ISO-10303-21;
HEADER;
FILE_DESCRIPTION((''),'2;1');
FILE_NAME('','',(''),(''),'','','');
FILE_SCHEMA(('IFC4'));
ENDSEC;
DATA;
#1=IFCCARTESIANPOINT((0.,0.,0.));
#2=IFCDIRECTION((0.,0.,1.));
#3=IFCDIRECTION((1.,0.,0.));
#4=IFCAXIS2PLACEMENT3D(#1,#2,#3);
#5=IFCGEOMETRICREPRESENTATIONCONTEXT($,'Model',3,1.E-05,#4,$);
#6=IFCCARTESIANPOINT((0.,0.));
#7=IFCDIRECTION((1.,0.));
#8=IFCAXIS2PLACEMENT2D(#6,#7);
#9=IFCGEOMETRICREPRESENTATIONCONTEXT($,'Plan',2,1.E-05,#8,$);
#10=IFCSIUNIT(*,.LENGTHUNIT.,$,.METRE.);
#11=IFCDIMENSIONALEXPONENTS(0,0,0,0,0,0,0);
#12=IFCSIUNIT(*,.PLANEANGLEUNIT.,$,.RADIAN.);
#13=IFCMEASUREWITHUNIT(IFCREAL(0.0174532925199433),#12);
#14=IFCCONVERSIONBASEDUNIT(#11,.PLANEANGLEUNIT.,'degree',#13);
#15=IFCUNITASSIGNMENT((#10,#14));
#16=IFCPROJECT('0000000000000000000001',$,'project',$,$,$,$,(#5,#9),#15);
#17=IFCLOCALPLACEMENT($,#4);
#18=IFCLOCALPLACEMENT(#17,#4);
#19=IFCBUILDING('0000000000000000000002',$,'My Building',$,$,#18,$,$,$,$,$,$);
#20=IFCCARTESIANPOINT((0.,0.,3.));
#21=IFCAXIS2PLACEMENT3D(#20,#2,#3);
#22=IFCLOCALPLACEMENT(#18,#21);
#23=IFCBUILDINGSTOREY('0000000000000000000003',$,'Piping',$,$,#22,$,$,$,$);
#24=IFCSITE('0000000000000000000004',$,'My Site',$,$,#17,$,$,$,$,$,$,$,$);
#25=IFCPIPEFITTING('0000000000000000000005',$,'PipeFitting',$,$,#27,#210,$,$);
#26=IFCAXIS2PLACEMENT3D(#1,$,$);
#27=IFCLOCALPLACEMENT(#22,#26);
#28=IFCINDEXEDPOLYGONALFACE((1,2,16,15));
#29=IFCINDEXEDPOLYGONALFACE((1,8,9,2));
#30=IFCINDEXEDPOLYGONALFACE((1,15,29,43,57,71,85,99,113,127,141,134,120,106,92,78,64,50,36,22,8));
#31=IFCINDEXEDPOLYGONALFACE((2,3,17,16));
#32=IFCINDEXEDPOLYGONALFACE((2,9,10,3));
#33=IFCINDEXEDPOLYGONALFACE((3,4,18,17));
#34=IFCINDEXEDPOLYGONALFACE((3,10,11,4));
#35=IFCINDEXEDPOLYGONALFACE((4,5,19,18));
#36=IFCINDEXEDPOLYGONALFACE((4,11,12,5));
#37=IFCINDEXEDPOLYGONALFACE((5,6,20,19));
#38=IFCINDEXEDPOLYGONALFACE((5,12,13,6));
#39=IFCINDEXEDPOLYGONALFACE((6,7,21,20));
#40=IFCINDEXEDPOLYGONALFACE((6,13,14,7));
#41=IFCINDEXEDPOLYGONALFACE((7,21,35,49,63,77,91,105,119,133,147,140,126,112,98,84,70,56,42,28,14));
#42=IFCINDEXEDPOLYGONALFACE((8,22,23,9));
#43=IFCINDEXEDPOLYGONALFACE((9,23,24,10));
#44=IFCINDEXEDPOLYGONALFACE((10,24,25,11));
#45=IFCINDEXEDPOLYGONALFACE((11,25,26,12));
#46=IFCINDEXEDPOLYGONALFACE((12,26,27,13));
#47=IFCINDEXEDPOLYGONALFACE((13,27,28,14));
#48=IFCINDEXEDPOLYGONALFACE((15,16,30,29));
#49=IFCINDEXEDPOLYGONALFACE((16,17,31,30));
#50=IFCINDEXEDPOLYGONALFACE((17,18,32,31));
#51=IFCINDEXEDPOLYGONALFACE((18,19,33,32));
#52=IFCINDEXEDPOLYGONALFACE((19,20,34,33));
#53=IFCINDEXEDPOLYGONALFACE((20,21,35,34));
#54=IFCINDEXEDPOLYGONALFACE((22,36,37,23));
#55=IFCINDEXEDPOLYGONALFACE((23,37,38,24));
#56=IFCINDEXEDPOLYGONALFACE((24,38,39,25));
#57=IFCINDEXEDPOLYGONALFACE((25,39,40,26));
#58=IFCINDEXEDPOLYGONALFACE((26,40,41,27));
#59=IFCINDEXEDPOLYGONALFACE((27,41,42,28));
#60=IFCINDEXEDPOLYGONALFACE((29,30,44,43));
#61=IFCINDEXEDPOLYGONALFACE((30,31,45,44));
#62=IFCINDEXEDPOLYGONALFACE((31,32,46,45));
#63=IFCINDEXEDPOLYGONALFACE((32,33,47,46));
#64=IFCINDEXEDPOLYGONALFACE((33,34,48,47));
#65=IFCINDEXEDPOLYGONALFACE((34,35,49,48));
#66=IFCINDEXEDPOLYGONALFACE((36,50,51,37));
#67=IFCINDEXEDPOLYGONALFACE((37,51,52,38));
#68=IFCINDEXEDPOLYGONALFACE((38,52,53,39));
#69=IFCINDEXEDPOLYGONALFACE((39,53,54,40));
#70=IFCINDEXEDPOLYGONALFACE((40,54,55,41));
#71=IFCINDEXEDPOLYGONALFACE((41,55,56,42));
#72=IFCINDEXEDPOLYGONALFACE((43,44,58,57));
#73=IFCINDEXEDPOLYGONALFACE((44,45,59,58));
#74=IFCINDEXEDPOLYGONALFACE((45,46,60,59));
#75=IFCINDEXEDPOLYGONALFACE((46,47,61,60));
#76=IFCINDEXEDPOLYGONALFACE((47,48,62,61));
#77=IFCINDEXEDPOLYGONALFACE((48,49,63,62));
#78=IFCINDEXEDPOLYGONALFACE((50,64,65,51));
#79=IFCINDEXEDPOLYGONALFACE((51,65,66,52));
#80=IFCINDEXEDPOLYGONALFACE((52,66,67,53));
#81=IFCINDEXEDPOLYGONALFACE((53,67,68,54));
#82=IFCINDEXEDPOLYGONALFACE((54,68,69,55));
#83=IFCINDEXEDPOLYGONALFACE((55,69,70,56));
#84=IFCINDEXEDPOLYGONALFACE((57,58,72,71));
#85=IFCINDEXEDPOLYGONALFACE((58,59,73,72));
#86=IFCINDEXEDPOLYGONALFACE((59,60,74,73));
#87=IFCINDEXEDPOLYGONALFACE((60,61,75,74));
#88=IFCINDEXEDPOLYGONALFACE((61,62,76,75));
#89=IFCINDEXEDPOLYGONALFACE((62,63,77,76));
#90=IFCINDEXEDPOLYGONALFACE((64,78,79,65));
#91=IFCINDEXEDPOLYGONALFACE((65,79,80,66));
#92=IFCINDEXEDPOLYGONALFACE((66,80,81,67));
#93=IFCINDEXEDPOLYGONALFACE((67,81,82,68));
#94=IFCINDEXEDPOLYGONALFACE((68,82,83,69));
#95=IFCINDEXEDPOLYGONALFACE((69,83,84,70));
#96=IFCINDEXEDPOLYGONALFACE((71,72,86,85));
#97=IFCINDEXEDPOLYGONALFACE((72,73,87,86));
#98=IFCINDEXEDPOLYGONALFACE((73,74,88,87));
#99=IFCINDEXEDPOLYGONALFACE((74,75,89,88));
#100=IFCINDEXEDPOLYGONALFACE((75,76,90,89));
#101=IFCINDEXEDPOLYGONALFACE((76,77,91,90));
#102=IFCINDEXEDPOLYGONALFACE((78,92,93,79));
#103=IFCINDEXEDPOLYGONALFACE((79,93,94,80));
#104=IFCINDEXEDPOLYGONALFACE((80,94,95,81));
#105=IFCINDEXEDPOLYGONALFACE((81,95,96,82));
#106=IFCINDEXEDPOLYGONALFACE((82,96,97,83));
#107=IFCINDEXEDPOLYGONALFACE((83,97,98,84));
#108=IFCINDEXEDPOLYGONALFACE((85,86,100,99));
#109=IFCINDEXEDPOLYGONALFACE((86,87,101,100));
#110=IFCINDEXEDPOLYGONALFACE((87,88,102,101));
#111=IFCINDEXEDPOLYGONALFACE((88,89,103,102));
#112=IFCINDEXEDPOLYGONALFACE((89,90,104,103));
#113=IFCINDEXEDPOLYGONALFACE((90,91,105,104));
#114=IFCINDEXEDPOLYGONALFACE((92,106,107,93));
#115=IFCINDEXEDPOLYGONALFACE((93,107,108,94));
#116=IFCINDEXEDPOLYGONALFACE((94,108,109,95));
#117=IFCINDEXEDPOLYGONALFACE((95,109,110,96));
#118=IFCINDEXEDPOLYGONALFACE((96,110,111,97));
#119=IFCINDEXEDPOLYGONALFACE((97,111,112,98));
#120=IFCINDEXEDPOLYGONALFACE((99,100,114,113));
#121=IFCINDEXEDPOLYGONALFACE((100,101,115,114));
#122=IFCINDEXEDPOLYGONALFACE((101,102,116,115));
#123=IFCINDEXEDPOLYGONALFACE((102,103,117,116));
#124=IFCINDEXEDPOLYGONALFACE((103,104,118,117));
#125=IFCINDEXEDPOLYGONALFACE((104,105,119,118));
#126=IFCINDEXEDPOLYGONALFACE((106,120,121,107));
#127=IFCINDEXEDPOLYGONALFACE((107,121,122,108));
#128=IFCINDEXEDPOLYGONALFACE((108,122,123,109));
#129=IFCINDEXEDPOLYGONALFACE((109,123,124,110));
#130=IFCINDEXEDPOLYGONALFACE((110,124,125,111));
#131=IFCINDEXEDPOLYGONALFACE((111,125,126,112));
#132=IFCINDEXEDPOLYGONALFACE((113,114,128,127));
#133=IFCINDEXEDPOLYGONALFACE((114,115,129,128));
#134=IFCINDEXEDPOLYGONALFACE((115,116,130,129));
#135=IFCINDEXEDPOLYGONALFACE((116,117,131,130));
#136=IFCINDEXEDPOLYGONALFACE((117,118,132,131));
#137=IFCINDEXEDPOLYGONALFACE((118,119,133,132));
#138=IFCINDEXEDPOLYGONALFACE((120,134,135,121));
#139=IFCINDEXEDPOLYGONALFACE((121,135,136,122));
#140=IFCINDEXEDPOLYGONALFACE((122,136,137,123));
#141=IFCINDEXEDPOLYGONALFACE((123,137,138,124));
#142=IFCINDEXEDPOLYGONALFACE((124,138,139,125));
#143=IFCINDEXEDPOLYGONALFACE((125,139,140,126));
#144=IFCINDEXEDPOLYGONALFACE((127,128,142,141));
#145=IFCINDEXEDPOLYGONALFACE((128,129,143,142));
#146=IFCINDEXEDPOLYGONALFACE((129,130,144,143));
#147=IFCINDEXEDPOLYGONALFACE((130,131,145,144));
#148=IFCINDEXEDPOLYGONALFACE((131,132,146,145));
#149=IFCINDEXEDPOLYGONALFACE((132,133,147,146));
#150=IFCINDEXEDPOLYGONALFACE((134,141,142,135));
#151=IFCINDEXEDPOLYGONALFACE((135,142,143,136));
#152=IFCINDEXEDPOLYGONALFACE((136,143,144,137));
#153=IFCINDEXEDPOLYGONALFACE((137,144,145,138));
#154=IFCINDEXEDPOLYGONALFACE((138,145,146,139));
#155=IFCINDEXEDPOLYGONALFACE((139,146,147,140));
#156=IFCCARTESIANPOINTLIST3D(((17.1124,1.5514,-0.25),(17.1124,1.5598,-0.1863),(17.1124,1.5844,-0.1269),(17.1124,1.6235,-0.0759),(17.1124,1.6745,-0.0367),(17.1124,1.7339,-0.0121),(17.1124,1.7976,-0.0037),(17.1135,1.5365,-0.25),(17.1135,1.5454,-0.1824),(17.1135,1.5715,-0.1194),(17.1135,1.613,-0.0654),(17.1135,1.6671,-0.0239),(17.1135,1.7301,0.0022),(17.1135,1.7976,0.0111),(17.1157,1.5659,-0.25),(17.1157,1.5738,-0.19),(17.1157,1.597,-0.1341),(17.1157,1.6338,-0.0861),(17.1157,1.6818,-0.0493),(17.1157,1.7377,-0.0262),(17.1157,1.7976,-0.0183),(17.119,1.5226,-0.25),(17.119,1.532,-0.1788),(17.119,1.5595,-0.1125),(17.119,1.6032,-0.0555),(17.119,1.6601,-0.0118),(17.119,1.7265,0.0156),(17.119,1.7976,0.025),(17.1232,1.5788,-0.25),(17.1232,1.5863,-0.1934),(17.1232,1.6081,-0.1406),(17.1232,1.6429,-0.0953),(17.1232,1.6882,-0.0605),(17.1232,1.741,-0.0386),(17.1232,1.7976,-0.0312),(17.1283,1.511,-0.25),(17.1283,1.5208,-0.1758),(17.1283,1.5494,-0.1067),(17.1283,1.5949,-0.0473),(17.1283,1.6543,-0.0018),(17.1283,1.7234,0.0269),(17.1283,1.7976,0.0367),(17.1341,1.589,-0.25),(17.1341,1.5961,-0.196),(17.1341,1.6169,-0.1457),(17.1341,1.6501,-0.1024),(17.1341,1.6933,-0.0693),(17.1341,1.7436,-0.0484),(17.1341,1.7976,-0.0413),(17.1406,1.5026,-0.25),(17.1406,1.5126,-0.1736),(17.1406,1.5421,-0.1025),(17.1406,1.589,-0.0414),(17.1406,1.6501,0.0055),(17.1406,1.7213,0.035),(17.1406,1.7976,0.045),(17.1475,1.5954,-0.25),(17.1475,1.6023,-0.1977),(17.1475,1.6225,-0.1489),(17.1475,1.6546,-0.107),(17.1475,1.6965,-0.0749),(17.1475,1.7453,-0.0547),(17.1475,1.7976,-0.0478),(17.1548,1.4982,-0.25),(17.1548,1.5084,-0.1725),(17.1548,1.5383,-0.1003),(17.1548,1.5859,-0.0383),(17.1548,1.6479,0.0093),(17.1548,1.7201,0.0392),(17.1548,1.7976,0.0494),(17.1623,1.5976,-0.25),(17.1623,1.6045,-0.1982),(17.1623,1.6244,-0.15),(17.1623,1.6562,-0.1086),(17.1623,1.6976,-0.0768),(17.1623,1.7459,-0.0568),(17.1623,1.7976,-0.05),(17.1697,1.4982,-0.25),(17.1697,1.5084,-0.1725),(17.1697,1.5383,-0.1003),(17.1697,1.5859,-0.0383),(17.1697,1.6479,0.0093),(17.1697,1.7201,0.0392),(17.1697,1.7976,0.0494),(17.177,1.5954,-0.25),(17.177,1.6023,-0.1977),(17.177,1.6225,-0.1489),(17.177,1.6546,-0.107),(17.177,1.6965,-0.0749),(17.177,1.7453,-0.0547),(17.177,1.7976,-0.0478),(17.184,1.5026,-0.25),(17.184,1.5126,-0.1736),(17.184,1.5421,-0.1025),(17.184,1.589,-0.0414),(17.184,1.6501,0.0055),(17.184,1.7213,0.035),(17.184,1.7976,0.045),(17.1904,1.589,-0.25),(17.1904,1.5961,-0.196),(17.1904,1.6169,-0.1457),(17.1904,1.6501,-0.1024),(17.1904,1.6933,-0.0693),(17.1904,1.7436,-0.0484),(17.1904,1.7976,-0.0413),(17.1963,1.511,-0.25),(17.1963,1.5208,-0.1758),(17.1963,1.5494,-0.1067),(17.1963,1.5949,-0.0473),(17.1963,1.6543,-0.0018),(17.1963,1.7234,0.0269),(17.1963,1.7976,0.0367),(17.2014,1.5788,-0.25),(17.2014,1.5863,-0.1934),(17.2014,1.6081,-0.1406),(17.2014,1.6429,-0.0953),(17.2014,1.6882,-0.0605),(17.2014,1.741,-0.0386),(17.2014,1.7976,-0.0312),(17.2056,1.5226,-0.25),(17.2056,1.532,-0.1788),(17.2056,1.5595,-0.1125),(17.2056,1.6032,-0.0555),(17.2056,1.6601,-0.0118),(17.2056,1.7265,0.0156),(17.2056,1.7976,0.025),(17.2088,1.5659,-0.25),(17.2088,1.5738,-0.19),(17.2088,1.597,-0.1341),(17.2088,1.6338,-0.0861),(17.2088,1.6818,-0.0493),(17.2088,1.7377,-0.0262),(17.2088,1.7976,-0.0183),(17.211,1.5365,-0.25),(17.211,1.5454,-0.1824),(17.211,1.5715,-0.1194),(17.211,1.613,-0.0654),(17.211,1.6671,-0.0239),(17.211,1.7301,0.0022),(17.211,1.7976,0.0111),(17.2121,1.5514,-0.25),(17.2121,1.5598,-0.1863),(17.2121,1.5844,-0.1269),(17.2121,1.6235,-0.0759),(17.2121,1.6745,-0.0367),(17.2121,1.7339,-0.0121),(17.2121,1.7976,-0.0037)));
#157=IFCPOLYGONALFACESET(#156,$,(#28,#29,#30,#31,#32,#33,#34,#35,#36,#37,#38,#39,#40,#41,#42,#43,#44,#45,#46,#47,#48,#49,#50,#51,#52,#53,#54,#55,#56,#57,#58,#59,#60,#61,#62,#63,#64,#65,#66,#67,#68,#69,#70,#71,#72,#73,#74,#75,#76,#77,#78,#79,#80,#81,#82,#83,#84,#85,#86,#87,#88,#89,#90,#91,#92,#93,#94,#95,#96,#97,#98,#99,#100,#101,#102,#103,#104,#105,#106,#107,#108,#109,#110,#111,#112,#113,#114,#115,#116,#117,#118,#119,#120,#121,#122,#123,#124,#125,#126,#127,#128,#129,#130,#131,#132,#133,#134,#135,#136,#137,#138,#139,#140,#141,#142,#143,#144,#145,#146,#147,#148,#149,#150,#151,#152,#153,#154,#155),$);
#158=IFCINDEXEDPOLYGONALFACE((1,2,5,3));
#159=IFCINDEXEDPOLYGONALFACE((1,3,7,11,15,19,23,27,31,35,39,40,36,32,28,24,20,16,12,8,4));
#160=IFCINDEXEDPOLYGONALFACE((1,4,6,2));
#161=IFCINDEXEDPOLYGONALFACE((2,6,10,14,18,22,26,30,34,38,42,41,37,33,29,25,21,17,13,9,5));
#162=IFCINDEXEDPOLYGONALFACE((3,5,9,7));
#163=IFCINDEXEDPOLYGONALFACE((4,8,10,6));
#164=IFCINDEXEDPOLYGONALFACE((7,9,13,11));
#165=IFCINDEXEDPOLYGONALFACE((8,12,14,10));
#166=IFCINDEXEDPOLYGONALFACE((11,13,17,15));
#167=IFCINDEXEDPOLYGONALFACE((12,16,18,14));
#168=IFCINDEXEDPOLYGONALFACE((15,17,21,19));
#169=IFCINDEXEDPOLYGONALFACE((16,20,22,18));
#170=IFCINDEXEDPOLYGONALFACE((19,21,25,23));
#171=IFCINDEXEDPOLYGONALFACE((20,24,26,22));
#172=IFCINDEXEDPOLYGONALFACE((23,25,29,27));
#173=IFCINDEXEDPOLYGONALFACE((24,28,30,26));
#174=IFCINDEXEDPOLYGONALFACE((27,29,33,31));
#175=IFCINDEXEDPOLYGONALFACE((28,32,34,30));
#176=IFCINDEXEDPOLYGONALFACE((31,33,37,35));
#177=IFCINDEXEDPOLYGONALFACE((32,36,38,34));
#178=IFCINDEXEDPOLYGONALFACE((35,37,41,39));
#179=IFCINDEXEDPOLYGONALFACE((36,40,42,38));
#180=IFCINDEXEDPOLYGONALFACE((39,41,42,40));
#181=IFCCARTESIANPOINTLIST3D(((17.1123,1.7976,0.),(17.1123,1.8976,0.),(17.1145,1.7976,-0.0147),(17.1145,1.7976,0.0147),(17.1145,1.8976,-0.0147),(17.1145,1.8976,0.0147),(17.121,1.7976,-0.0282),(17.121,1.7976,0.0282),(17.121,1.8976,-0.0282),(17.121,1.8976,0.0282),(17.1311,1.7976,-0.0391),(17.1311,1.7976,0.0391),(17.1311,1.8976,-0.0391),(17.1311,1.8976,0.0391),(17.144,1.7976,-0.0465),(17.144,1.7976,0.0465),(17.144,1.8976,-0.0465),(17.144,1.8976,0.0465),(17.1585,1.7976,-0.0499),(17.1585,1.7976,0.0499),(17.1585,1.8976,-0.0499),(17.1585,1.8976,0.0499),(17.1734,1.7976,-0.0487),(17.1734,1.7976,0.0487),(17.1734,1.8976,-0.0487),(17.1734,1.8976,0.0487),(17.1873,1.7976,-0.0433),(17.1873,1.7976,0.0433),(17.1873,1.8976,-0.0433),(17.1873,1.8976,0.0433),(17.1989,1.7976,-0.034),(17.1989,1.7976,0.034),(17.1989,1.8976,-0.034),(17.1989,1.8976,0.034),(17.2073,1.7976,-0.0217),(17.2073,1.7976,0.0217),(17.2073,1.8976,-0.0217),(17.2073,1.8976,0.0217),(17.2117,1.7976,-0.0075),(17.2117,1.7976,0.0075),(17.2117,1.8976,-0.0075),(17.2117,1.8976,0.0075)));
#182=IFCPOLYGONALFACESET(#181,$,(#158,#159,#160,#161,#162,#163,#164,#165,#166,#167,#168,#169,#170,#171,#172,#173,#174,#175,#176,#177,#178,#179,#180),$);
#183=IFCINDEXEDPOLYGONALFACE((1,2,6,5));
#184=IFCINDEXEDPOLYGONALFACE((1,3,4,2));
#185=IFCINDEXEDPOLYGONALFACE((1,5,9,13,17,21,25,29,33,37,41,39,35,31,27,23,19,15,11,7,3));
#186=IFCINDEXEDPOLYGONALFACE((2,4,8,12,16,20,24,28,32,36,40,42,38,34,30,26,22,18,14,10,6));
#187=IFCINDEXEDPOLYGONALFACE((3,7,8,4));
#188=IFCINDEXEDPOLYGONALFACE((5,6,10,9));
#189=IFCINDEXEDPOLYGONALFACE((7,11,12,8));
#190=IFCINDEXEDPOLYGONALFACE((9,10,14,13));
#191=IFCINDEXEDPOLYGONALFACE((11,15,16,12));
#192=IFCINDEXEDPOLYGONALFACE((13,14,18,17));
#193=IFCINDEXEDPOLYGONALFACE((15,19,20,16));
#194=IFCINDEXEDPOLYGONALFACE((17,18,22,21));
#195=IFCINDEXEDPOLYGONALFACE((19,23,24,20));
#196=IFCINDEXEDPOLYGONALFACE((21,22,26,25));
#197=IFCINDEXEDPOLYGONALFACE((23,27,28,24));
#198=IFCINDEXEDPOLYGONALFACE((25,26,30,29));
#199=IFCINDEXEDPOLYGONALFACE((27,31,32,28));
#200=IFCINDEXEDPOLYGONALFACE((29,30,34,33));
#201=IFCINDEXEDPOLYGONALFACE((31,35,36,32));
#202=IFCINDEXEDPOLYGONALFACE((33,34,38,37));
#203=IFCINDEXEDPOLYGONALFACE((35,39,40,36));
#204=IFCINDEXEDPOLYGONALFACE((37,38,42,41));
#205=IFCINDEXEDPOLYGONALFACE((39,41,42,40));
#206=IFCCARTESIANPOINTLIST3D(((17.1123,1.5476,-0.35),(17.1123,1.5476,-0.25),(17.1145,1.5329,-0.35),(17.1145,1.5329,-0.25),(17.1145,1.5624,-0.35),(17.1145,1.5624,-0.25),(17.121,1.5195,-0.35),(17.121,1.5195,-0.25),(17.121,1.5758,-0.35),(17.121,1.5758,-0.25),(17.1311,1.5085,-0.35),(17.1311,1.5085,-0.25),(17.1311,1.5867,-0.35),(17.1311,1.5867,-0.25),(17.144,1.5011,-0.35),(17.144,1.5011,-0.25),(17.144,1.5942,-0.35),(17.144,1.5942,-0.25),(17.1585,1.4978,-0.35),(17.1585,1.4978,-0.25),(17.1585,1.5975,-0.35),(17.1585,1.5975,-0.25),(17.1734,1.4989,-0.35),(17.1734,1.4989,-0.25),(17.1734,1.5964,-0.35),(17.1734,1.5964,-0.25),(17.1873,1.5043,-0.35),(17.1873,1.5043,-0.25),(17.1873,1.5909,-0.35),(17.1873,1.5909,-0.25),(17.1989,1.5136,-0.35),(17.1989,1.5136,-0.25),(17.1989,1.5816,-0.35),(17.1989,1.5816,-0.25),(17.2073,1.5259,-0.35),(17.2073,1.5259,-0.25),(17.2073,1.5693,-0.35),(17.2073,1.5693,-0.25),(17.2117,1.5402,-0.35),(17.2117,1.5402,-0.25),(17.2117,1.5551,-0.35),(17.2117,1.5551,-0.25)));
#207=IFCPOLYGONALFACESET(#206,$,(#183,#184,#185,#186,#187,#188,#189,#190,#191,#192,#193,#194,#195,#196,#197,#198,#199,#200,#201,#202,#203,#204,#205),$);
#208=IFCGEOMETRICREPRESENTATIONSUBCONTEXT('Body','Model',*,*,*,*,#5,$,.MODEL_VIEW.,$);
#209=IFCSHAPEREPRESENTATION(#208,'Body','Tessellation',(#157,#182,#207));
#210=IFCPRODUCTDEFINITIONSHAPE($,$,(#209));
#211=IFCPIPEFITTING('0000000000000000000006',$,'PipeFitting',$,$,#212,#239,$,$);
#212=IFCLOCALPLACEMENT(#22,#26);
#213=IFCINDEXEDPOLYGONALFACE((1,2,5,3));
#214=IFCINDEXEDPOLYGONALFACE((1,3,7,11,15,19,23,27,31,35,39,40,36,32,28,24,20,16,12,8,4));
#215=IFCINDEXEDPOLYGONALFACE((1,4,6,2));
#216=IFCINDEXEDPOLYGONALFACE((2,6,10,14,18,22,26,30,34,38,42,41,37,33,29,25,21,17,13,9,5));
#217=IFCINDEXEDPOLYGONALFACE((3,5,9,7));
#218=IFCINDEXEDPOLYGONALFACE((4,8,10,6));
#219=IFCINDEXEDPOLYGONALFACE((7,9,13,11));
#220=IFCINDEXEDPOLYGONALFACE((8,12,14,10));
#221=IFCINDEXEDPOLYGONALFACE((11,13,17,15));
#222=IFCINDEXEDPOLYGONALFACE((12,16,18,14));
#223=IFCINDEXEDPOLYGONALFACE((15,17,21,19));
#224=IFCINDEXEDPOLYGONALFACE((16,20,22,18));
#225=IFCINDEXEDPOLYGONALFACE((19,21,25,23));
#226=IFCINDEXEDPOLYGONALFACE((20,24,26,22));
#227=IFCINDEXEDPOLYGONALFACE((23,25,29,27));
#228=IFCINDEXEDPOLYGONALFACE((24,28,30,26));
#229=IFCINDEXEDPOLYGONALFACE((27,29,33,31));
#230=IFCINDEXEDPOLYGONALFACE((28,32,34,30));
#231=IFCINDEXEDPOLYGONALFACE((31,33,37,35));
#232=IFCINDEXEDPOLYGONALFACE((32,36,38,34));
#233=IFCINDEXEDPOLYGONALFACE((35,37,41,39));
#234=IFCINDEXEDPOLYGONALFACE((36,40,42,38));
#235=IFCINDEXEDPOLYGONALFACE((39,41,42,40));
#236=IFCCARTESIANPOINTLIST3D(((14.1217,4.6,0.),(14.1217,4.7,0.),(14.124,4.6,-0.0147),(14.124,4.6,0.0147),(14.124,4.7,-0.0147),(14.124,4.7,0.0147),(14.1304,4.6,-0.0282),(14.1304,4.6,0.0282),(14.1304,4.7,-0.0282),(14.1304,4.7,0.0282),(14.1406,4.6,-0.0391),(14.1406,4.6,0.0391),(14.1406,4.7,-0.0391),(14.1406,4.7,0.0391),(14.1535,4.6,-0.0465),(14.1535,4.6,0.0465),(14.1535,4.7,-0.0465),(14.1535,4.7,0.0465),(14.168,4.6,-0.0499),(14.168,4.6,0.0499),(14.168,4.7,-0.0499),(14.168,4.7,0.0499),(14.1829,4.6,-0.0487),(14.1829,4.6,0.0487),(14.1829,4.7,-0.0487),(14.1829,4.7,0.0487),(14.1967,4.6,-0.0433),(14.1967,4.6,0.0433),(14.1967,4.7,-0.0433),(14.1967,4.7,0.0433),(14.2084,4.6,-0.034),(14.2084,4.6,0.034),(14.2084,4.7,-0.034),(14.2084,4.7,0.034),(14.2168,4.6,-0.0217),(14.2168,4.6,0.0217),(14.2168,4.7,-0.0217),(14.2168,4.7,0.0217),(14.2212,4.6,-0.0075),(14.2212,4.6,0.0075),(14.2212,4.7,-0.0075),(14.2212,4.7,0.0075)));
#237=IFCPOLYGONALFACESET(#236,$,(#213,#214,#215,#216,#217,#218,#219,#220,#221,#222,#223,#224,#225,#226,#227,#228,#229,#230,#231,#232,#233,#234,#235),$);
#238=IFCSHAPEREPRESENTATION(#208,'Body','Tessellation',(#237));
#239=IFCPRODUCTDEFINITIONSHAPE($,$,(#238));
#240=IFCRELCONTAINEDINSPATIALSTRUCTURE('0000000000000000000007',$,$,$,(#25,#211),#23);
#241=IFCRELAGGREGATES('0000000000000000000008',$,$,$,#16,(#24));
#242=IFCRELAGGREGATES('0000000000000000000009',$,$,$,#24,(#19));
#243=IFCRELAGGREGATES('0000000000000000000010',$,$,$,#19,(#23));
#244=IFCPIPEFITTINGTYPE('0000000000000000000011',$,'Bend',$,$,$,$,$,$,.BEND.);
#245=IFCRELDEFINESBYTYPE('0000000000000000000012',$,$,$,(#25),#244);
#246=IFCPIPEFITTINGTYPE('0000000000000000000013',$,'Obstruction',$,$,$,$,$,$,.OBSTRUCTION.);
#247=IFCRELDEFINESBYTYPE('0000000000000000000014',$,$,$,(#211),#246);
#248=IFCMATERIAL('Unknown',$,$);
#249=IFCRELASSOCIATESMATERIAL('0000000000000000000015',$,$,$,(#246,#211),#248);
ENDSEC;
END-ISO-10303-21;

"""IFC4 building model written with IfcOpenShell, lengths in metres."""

from ifc_helpers import new_model, entity, si_unit, converted_unit, frame, origin_with_axes, origin_2d_with_axis, place, context, subcontext, project, spatial, circle, extrude, source, transform, mapped, material, material_profile, profile_set, profile_usage, type_object, type_shapes, element, save


model = new_model("IFC4")

# Units and contexts
model_context = context("Model", 3, precision=1e-05, world=origin_with_axes())
plan_context = context("Plan", 2, precision=1e-05, world=origin_2d_with_axis())
body_context = subcontext(model_context, "Body", "Model", "MODEL_VIEW")
ifc_project = project(units=[si_unit("LENGTHUNIT", "METRE"), converted_unit("PLANEANGLEUNIT", "degree", entity("IfcReal", 0.0174532925199433), si_unit("PLANEANGLEUNIT", "RADIAN"), dimensions=[0, 0, 0, 0, 0, 0, 0])], contexts=[model_context, plan_context])

# Site, building, storey
site_placement = place(None, origin_with_axes())
site = spatial("IfcSite", under=ifc_project, at=site_placement, Name="My Site")
building_placement = place(site_placement, origin_with_axes())
building = spatial("IfcBuilding", under=site, at=building_placement, Name="My Building")
storey_placement = place(building_placement, frame((0.0, 0.0, 3.0), z_axis=(0.0, 0.0, 1.0), x_axis=(1.0, 0.0, 0.0)))
storey = spatial("IfcBuildingStorey", under=building, at=storey_placement, Name="Piping")

# Shared definitions
ifc_material = material(Name="Unknown")

# Pipe fittings
pipe_fitting_type_1 = type_object("IfcPipeFittingType", Name="Bend", PredefinedType="BEND")
shared_shape = source(origin_with_axes(), body_context, "Body", "SolidModel", [
    entity("IfcSweptDiskSolid", entity("IfcIndexedPolyCurve", entity("IfcCartesianPointList3D", [[0.0, 0.0, -0.1], [0.0, -0.0732, -0.2768], [0.0, -0.25, -0.35]]), [entity("IfcArcIndex", [1, 2, 3])]), 0.05),
    extrude(circle(Radius=0.05), origin_with_axes(), (0.0, 0.0, -1.0), 0.1),
    extrude(circle(Radius=0.05), frame((0.0, -0.25, -0.35), z_axis=(0.0, -1.0, 0.0), x_axis=(1.0, 0.0, 0.0)), (0.0, 0.0, 1.0), 0.1),
])
type_shapes(pipe_fitting_type_1, [shared_shape])
for number, where, z_axis, x_axis, name in (
    (1, (17.1623, 1.8976, 0.0), (0.0, 1.0, 0.0), (-1.0, 0.0, 0.0), "PipeFitting"),
):
    element("IfcPipeFitting", number, at=place(storey_placement, frame(where, z_axis=z_axis, x_axis=x_axis)), inside=storey, type_object=pipe_fitting_type_1, Name=name, context=body_context, shape_type="MappedRepresentation", body=[
        mapped(shared_shape, transform((0.0, 0.0, 0.0), x_axis=(1.0, 0.0, 0.0), y_axis=(0.0, 1.0, 0.0), z_axis=(0.0, 0.0, 1.0), scale=1.0)),
    ])
ifc_material_profile_1 = material_profile(ifc_material, circle(Radius=0.05))
ifc_profile_set_1 = profile_set([ifc_material_profile_1])
ifc_profile_usage_1 = profile_usage(ifc_profile_set_1, cardinal=5)
pipe_fitting_type_2 = type_object("IfcPipeFittingType", Name="Obstruction", PredefinedType="OBSTRUCTION", material=ifc_profile_set_1)
pipe_fitting_1_placement = place(storey_placement, frame((14.1717, 4.6, 0.0), z_axis=(0.0, 1.0, 0.0), x_axis=(-1.0, 0.0, 0.0)))
element("IfcPipeFitting", 2, at=pipe_fitting_1_placement, inside=storey, type_object=pipe_fitting_type_2, material=ifc_profile_usage_1, Name="PipeFitting", context=body_context, shape_type="SweptSolid", body=[
    extrude(circle(Radius=0.05), origin_with_axes(), (0.0, 0.0, 1.0), 0.1),
])

save(model, "model.ifc")
